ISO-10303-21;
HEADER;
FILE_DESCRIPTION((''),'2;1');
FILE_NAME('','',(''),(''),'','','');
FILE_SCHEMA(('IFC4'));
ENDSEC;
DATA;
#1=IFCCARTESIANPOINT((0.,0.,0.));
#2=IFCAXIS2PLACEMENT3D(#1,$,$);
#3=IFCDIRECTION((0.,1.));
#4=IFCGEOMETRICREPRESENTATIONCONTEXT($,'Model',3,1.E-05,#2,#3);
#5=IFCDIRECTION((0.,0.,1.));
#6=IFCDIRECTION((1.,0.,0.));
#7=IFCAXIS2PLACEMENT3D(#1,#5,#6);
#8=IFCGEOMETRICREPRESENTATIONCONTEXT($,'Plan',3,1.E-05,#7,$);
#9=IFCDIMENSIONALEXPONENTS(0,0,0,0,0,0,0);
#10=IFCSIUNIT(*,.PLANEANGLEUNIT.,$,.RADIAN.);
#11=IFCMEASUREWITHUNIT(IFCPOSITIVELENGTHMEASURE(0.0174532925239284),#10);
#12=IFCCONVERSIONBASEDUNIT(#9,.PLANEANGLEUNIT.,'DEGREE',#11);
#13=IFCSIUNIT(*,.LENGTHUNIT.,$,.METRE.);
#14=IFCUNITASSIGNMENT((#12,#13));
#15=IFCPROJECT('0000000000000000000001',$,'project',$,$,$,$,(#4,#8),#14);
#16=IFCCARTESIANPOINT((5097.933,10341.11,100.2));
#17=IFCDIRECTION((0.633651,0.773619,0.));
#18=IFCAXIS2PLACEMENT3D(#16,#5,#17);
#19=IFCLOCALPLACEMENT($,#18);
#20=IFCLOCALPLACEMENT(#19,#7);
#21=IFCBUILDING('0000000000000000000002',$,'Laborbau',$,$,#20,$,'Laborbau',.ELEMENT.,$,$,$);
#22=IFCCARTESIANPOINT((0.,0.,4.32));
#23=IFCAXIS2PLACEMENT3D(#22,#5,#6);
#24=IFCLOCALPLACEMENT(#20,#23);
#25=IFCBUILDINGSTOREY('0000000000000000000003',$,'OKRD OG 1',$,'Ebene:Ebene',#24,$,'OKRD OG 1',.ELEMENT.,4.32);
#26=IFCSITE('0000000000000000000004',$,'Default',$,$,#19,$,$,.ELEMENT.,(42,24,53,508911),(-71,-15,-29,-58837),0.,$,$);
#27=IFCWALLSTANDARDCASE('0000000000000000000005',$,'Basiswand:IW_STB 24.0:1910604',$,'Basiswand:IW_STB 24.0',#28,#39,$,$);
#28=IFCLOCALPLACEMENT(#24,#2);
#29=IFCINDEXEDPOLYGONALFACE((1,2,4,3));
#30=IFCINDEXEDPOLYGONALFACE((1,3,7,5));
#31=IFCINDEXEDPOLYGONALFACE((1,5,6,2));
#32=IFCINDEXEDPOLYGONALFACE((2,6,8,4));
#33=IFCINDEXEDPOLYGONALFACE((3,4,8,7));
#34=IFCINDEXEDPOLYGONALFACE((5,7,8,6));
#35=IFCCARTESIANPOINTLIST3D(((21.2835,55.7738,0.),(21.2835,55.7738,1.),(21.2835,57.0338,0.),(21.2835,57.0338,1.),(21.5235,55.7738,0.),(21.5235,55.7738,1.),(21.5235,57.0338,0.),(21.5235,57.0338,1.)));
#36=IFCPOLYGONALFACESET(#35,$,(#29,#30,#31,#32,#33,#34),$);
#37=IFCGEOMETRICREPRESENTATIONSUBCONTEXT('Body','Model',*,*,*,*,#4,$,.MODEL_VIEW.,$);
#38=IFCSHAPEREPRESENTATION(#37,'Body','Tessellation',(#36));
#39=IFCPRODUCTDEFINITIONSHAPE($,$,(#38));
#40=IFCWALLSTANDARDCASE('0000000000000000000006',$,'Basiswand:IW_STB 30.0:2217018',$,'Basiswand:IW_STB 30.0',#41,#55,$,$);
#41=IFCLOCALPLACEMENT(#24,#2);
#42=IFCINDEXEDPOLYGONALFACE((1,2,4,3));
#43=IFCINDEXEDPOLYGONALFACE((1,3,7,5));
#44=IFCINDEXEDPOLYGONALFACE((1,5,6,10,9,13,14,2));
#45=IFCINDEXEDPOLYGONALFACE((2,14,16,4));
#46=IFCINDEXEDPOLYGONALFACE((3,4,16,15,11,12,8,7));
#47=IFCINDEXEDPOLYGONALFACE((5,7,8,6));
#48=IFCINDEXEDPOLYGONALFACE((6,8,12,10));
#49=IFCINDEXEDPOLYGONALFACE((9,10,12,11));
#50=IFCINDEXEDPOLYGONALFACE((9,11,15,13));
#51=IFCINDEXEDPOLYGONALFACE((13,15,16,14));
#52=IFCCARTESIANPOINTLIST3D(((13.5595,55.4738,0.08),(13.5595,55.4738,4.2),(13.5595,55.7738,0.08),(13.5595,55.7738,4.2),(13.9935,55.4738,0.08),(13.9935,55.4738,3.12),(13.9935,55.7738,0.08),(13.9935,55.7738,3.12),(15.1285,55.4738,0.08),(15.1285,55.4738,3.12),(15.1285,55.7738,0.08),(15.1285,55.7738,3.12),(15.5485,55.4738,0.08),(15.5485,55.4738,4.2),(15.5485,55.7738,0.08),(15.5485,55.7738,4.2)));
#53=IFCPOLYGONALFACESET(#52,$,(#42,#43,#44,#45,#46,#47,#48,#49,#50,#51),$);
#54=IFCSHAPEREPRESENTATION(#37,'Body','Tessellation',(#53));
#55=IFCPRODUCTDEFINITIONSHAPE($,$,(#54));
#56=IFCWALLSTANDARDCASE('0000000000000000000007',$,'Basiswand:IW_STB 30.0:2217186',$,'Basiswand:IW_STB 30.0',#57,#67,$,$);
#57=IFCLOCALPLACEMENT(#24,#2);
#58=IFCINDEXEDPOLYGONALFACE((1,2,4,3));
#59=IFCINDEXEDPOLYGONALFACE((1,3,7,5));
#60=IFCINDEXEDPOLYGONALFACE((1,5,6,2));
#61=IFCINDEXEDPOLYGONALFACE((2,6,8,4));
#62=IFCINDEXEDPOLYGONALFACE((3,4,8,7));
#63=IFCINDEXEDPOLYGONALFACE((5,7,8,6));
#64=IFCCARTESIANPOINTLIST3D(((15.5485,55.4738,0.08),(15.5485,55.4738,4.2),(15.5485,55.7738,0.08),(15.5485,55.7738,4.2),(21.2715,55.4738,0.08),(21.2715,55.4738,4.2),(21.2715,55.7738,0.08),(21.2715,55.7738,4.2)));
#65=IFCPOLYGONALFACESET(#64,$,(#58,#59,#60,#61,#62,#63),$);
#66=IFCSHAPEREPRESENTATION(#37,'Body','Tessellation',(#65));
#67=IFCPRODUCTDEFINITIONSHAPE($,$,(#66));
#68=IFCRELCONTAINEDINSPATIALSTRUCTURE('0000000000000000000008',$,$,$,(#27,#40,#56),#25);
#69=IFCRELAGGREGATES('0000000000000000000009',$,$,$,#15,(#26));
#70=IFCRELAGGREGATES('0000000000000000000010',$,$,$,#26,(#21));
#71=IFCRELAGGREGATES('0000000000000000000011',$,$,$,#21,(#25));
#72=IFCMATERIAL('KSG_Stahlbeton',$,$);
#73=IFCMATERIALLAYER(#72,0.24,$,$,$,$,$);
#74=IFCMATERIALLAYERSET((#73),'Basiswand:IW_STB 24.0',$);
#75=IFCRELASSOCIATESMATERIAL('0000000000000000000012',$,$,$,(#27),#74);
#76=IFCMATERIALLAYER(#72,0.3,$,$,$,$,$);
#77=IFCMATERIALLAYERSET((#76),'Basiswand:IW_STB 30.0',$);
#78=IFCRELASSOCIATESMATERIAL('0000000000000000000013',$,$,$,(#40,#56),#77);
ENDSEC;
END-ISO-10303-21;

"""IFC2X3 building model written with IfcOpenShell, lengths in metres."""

from ifc_helpers import new_model, entity, si_unit, converted_unit, direction, frame, frame_2d, origin, origin_with_axes, place, context, subcontext, project, spatial, rectangle, extrude, material, layer, layer_set, layer_usage, element, save


model = new_model("IFC2X3")

# Units and contexts
model_context = context("Model", 3, precision=1e-05, world=origin(), true_north=direction((0.0, 1.0)))
plan_context = context("Plan", 3, precision=1e-05, world=origin_with_axes())
body_context = subcontext(model_context, "Body", "Model", "MODEL_VIEW")
ifc_project = project(units=[converted_unit("PLANEANGLEUNIT", "DEGREE", entity("IfcPositiveLengthMeasure", 0.0174532925239284), si_unit("PLANEANGLEUNIT", "RADIAN"), dimensions=[0, 0, 0, 0, 0, 0, 0]), si_unit("LENGTHUNIT", "METRE")], contexts=[model_context, plan_context])

# Site, building, storey
site_placement = place(None, frame((5097.933, 10341.11, 100.2), z_axis=(0.0, 0.0, 1.0), x_axis=(0.633651, 0.773619, 0.0)))
site = spatial("IfcSite", under=ifc_project, at=site_placement, Name="Default", CompositionType="ELEMENT", RefLatitude=(42, 24, 53, 508911), RefLongitude=(-71, -15, -29, -58837), RefElevation=0.0)
building_placement = place(site_placement, origin_with_axes())
building = spatial("IfcBuilding", under=site, at=building_placement, Name="Laborbau", LongName="Laborbau", CompositionType="ELEMENT")
storey_placement = place(building_placement, frame((0.0, 0.0, 4.32), z_axis=(0.0, 0.0, 1.0), x_axis=(1.0, 0.0, 0.0)))
storey = spatial("IfcBuildingStorey", under=building, at=storey_placement, Name="OKRD OG 1", ObjectType="Ebene:Ebene", LongName="OKRD OG 1", CompositionType="ELEMENT", Elevation=4.32)

# Wall
ifc_material_1 = material(Name="KSG_Stahlbeton")
ifc_layer_1 = layer(ifc_material_1, 0.24)
ifc_layer_set_1 = layer_set([ifc_layer_1], Name="Basiswand:IW_STB 24.0")
ifc_layer_usage_1 = layer_usage(ifc_layer_set_1, "AXIS2", "NEGATIVE", 0.12)
wall_1_placement = place(storey_placement, frame((21.4035, 57.0338, 0.0), z_axis=(0.0, 0.0, 1.0), x_axis=(0.0, -1.0, 0.0)))
element("IfcWallStandardCase", 1, at=wall_1_placement, inside=storey, material=ifc_layer_usage_1, Name="Basiswand:IW_STB 24.0:1910604", ObjectType="Basiswand:IW_STB 24.0", context=body_context, shape_type="SweptSolid", body=[
    extrude(rectangle(XDim=1.26, YDim=0.24, at=frame_2d((0.63, 0.0), x_axis=(-1.0, 0.0))), origin(), (0.0, 0.0, 1.0), 1.0),
])

# Wall, openings
ifc_layer_2 = layer(ifc_material_1, 0.3)
ifc_layer_set_2 = layer_set([ifc_layer_2], Name="Basiswand:IW_STB 30.0")
ifc_layer_usage_2 = layer_usage(ifc_layer_set_2, "AXIS2", "NEGATIVE", 0.15)
wall_2_placement = place(storey_placement, frame((15.5485, 55.6238, 0.08), z_axis=(0.0, 0.0, 1.0), x_axis=(-1.0, 0.0, 0.0)))
wall_2 = element("IfcWallStandardCase", 2, at=wall_2_placement, inside=storey, material=ifc_layer_usage_2, Name="Basiswand:IW_STB 30.0:2217018", ObjectType="Basiswand:IW_STB 30.0", context=body_context, shape_type="SweptSolid", body=[
    extrude(rectangle(XDim=1.989, YDim=0.3, at=frame_2d((0.9945, 0.0), x_axis=(-1.0, 0.0))), origin(), (0.0, 0.0, 1.0), 4.12),
])
opening_1_placement = place(wall_2_placement, frame((1.555, 0.15, 0.0), z_axis=(0.0, 0.0, 1.0), x_axis=(1.0, 0.0, 0.0)))
element("IfcOpeningElement", 3, at=opening_1_placement, cuts=wall_2, ObjectType="Opening", context=body_context, shape_type="SweptSolid", body=[
    extrude(rectangle(XDim=3.04, YDim=1.135, at=frame_2d((1.52, 0.5675), x_axis=(1.0, 0.0))), frame((0.0, 0.0, 0.0), z_axis=(0.0, -1.0, 0.0), x_axis=(0.0, 0.0, 1.0)), (0.0, 0.0, 1.0), 0.3),
])
opening_2_placement = place(wall_2_placement, frame((15.5485, 55.6238, -0.08), z_axis=(0.0, 0.0, 1.0), x_axis=(-1.0, 0.0, 0.0)))
element("IfcOpeningElement", 4, at=opening_2_placement, cuts=wall_2, ObjectType="Opening", context=body_context, shape_type="SweptSolid", body=[
    extrude(rectangle(XDim=3.04, YDim=1.135, at=frame_2d((0.0, 0.0), x_axis=(0.0, 1.0))), frame((14.561, 57.2978, 1.6), z_axis=(0.0, -1.0, 0.0), x_axis=(1.0, 0.0, 0.0)), (0.0, 0.0, 1.0), 3.048),
])

# Wall
ifc_layer_usage_3 = layer_usage(ifc_layer_set_2, "AXIS2", "NEGATIVE", 0.15)
wall_3_placement = place(storey_placement, frame((21.2715, 55.6238, 0.08), z_axis=(0.0, 0.0, 1.0), x_axis=(-1.0, 0.0, 0.0)))
element("IfcWallStandardCase", 5, at=wall_3_placement, inside=storey, material=ifc_layer_usage_3, Name="Basiswand:IW_STB 30.0:2217186", ObjectType="Basiswand:IW_STB 30.0", context=body_context, shape_type="SweptSolid", body=[
    extrude(rectangle(XDim=5.723, YDim=0.3, at=frame_2d((2.8615, 0.0), x_axis=(-1.0, 0.0))), origin(), (0.0, 0.0, 1.0), 4.12),
])

save(model, "model.ifc")
